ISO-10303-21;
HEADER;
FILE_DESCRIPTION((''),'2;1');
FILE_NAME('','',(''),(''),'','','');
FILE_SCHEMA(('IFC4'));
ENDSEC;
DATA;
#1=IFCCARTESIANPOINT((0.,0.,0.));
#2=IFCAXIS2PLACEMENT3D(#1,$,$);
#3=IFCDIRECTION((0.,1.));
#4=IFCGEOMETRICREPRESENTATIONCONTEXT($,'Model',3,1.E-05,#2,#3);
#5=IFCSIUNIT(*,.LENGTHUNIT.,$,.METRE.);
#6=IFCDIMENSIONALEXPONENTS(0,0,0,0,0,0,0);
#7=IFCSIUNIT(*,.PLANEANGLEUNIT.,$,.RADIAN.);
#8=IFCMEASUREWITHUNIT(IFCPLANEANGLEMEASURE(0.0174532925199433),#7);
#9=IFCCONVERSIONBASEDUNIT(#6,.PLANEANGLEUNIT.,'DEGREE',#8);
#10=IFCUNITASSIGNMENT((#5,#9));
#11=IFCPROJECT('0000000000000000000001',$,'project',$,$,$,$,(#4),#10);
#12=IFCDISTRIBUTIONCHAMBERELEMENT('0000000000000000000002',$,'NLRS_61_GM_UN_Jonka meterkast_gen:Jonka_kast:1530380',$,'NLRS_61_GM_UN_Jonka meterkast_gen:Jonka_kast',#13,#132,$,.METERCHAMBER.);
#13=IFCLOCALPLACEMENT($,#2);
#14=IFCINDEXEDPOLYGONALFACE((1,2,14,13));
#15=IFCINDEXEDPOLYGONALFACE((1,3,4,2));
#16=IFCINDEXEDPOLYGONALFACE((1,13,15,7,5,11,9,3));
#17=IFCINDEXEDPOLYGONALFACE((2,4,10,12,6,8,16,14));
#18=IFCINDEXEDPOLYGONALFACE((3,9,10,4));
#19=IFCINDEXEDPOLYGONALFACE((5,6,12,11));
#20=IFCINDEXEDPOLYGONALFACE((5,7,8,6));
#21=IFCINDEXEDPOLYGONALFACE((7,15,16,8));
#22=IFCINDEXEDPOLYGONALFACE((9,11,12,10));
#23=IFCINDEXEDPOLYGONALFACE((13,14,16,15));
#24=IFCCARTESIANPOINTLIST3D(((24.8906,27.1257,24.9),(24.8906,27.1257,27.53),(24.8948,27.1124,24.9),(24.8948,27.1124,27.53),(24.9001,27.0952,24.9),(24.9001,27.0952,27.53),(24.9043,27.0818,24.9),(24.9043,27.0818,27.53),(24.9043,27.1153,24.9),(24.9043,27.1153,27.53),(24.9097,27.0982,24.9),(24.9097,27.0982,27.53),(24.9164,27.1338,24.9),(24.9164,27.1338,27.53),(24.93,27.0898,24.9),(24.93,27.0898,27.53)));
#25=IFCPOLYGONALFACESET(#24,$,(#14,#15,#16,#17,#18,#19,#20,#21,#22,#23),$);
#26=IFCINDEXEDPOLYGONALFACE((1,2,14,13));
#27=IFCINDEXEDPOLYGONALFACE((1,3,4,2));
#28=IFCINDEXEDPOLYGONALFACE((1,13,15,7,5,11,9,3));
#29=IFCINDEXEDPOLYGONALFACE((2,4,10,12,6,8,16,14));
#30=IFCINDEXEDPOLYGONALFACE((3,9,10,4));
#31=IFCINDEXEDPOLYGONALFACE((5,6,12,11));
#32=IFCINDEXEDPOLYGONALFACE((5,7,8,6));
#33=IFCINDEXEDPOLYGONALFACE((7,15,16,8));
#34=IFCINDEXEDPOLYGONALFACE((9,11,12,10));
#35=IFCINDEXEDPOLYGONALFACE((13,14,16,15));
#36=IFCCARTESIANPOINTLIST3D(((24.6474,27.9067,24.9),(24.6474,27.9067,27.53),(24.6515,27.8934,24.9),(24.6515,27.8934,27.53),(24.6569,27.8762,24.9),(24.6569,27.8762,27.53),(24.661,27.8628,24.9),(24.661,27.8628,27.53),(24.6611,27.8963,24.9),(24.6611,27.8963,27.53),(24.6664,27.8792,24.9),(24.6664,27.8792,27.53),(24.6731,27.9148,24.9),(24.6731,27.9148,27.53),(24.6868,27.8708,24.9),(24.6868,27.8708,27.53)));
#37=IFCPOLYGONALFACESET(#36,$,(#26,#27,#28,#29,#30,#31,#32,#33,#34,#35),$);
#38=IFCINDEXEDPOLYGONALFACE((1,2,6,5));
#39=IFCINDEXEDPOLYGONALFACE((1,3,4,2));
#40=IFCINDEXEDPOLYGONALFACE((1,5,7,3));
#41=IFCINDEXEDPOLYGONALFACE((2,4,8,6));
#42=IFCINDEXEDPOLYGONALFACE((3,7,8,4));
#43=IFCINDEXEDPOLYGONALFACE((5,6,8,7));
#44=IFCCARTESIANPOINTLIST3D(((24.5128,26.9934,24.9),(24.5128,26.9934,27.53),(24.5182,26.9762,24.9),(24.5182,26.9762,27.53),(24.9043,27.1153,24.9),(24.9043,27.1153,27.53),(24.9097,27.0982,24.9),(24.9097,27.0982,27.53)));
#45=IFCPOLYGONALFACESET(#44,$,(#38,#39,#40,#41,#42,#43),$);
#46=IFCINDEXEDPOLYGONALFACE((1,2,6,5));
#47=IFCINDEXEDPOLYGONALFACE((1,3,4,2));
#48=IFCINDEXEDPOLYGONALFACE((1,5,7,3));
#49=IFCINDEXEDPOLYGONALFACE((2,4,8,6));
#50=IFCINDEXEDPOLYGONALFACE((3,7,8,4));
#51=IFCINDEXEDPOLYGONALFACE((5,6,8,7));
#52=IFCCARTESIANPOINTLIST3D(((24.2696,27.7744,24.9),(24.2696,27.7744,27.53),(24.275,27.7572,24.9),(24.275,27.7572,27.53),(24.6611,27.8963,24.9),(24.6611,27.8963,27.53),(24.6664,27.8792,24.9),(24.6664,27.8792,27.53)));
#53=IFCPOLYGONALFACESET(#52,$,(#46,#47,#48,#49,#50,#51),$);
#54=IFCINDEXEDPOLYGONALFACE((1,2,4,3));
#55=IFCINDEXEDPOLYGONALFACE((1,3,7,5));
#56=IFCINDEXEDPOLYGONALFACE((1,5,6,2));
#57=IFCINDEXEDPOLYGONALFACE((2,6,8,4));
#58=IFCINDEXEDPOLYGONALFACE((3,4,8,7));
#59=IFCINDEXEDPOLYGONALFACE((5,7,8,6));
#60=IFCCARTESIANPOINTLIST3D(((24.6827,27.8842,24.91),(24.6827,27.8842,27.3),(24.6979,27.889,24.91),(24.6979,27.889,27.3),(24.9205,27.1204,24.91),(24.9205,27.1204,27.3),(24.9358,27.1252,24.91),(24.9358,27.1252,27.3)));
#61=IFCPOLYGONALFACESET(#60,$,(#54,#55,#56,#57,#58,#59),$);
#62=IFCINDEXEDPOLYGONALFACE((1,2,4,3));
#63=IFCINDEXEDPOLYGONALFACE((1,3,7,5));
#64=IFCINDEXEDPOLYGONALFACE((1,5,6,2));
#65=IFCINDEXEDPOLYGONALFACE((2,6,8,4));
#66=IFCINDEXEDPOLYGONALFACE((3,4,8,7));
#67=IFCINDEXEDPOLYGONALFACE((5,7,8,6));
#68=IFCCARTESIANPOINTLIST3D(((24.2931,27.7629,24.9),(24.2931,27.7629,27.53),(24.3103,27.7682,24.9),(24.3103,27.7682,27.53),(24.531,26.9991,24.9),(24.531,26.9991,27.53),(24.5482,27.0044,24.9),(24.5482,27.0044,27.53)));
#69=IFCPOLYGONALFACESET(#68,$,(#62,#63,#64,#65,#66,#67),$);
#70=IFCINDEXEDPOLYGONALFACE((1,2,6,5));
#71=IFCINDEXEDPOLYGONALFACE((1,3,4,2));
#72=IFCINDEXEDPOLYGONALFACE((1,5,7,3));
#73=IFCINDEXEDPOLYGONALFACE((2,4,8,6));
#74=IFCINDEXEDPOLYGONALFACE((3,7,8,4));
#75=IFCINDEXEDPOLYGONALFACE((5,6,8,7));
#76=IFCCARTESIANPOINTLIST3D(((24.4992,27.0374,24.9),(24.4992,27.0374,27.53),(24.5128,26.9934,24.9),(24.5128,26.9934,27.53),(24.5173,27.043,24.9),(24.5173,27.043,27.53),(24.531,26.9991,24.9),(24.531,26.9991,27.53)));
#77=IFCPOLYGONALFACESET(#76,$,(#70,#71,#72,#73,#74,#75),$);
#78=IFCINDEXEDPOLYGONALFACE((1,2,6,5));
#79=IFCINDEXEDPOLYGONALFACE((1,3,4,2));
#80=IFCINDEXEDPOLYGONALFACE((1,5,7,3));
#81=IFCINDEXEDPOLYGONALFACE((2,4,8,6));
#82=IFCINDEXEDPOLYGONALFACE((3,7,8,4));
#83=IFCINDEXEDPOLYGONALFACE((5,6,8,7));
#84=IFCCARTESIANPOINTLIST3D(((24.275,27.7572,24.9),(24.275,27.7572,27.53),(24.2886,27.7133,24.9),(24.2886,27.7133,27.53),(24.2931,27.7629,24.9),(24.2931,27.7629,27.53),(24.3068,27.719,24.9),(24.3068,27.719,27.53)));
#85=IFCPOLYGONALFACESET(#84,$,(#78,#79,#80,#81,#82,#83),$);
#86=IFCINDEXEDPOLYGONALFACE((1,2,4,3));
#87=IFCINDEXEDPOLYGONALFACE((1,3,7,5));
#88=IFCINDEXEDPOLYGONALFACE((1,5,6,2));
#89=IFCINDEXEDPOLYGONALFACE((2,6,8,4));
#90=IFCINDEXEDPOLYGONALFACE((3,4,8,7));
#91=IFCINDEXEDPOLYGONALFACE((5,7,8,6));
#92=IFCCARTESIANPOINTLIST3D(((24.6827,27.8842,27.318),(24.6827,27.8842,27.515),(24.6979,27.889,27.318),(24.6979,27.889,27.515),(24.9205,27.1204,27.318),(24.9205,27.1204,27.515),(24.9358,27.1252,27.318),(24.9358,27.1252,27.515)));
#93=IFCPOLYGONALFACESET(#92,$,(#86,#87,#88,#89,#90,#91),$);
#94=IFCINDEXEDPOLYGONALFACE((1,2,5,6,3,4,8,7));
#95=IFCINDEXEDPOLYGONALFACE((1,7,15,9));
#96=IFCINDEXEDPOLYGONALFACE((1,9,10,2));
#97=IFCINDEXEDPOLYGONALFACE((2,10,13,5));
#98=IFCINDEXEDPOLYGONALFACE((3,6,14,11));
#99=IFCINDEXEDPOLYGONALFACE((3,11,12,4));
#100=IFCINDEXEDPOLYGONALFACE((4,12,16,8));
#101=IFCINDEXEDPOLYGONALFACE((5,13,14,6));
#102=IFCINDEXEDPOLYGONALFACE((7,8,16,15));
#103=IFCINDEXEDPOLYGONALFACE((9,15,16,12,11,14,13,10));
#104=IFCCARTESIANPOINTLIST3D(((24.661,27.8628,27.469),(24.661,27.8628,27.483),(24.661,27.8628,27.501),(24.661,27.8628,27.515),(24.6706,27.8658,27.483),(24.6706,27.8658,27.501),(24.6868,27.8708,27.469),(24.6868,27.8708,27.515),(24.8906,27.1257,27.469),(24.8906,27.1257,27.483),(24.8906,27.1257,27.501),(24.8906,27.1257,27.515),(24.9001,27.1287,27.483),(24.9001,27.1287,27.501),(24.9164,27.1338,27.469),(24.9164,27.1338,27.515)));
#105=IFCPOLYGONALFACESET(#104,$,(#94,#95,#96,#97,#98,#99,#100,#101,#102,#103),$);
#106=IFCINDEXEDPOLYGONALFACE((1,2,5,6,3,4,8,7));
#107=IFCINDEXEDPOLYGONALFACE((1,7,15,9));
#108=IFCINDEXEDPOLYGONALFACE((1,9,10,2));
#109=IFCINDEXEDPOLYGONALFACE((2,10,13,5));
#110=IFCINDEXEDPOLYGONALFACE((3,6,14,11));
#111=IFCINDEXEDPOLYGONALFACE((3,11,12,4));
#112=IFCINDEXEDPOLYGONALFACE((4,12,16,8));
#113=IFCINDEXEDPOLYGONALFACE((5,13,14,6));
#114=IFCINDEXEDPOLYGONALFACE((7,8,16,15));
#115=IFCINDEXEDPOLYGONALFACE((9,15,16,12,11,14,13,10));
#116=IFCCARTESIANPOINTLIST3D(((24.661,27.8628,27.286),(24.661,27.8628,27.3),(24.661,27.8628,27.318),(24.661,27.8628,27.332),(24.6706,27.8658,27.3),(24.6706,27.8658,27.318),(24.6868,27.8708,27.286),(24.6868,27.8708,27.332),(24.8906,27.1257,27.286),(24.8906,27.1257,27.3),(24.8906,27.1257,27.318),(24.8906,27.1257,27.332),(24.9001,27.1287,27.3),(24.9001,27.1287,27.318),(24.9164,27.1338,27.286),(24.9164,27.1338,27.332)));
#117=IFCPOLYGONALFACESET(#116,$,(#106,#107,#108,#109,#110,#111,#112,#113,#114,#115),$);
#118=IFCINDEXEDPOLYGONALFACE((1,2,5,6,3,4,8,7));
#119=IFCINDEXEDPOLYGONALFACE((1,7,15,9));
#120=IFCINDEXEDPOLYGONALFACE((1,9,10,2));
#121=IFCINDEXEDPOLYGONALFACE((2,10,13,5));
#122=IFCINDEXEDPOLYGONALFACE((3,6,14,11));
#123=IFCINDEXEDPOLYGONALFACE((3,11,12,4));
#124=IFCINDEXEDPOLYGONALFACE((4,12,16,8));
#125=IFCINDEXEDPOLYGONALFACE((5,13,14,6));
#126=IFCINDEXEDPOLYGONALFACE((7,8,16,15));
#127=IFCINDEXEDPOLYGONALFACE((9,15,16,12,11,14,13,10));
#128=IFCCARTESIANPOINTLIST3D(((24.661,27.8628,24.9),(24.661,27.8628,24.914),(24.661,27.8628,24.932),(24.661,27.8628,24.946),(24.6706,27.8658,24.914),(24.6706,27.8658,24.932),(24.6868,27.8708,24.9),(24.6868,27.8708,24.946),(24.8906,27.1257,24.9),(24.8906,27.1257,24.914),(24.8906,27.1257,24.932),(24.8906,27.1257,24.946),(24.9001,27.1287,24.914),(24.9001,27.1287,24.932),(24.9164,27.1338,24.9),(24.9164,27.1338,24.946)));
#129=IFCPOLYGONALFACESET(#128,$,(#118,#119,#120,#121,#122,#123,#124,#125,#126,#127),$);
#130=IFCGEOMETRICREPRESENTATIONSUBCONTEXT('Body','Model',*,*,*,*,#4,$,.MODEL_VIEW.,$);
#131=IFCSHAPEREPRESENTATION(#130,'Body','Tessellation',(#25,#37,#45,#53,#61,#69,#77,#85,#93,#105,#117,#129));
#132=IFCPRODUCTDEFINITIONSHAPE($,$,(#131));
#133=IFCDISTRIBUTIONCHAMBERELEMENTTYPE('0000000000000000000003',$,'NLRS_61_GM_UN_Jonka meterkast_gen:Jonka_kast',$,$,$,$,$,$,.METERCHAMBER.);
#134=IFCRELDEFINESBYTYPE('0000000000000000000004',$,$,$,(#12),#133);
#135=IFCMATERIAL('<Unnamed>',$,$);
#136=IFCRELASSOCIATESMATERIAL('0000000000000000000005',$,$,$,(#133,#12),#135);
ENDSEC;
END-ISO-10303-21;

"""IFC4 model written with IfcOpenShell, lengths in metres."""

from ifc_helpers import new_model, entity, si_unit, converted_unit, direction, frame, origin, place, context, subcontext, project, indexed_curve, outline, extrude, source, transform, mapped, material, type_object, type_shapes, element, save


model = new_model("IFC4")

# Units and contexts
model_context = context("Model", 3, precision=1e-05, world=origin(), true_north=direction((0.0, 1.0)))
body_context = subcontext(model_context, "Body", "Model", "MODEL_VIEW")
ifc_project = project(units=[si_unit("LENGTHUNIT", "METRE"), converted_unit("PLANEANGLEUNIT", "DEGREE", entity("IfcPlaneAngleMeasure", 0.0174532925199433), si_unit("PLANEANGLEUNIT", "RADIAN"), dimensions=[0, 0, 0, 0, 0, 0, 0])], contexts=[model_context])

# Distribution chamber element
ifc_material = material(Name="<Unnamed>")
distribution_chamber_element_type = type_object("IfcDistributionChamberElementType", Name="NLRS_61_GM_UN_Jonka meterkast_gen:Jonka_kast", PredefinedType="METERCHAMBER", material=ifc_material)
shared_shape_1 = source(origin(), body_context, "Body", "SweptSolid", [
    extrude(outline(indexed_curve([(-0.0093, -0.023), (0.0178, -0.023), (0.0178, 0.023), (-0.0093, 0.023), (-0.0093, 0.009), (0.0007, 0.009), (0.0007, -0.009), (-0.0093, -0.009), (-0.0093, -0.023)], self_intersect=False)), frame((-0.409, -0.4092, 0.0), z_axis=(0.0, 0.0, 1.0), x_axis=(0.0, -1.0, 0.0)), (0.0, 0.0, 1.0), 2.63),
    extrude(outline(indexed_curve([(-0.0093, -0.023), (0.0178, -0.023), (0.0178, 0.023), (-0.0093, 0.023), (-0.0093, 0.009), (0.0007, 0.009), (0.0007, -0.009), (-0.0093, -0.009), (-0.0093, -0.023)], self_intersect=False)), frame((0.409, -0.4092, 0.0), z_axis=(0.0, 0.0, 1.0), x_axis=(0.0, -1.0, 0.0)), (0.0, 0.0, 1.0), 2.63),
    extrude(outline(indexed_curve([(-0.205, -0.009), (0.205, -0.009), (0.205, 0.009), (-0.205, 0.009), (-0.205, -0.009)], self_intersect=False)), frame((-0.409, -0.205, 0.0), z_axis=(0.0, 0.0, 1.0), x_axis=(0.0, -1.0, 0.0)), (0.0, 0.0, 1.0), 2.63),
    extrude(outline(indexed_curve([(-0.205, -0.009), (0.205, -0.009), (0.205, 0.009), (-0.205, 0.009), (-0.205, -0.009)], self_intersect=False)), frame((0.409, -0.205, 0.0), z_axis=(0.0, 0.0, 1.0), x_axis=(0.0, -1.0, 0.0)), (0.0, 0.0, 1.0), 2.63),
    extrude(outline(indexed_curve([(-0.4, -0.008), (0.4, -0.008), (0.4, 0.008), (-0.4, 0.008), (-0.4, -0.008)], self_intersect=False)), frame((0.0, -0.435, 0.01), z_axis=(0.0, 0.0, 1.0), x_axis=(-1.0, 0.0, 0.0)), (0.0, 0.0, 1.0), 2.39),
    extrude(outline(indexed_curve([(-0.4, -0.009), (0.4, -0.009), (0.4, 0.009), (-0.4, 0.009), (-0.4, -0.009)], self_intersect=False)), frame((0.0, -0.028, 0.0), z_axis=(0.0, 0.0, 1.0), x_axis=(-1.0, 0.0, 0.0)), (0.0, 0.0, 1.0), 2.63),
    extrude(outline(indexed_curve([(-0.023, -0.0095), (0.023, -0.0095), (0.023, 0.0095), (-0.023, 0.0095), (-0.023, -0.0095)], self_intersect=False)), frame((-0.377, -0.0095, 0.0), z_axis=(0.0, 0.0, 1.0), x_axis=(-1.0, 0.0, 0.0)), (0.0, 0.0, 1.0), 2.63),
    extrude(outline(indexed_curve([(-0.023, -0.0095), (0.023, -0.0095), (0.023, 0.0095), (-0.023, 0.0095), (-0.023, -0.0095)], self_intersect=False)), frame((0.377, -0.0095, 0.0), z_axis=(0.0, 0.0, 1.0), x_axis=(-1.0, 0.0, 0.0)), (0.0, 0.0, 1.0), 2.63),
    extrude(outline(indexed_curve([(-0.4, -0.008), (0.4, -0.008), (0.4, 0.008), (-0.4, 0.008), (-0.4, -0.008)], self_intersect=False)), frame((0.0, -0.435, 2.418), z_axis=(0.0, 0.0, 1.0), x_axis=(-1.0, 0.0, 0.0)), (0.0, 0.0, 1.0), 0.197),
    extrude(outline(indexed_curve([(-0.023, -0.0178), (0.023, -0.0178), (0.023, 0.0093), (0.009, 0.0093), (0.009, -0.0007), (-0.009, -0.0007), (-0.009, 0.0093), (-0.023, 0.0093), (-0.023, -0.0178)], self_intersect=False)), frame((-0.386, -0.4092, 2.592), z_axis=(1.0, 0.0, 0.0), x_axis=(0.0, 0.0, -1.0)), (0.0, 0.0, 1.0), 0.772),
    extrude(outline(indexed_curve([(-0.023, -0.0178), (0.023, -0.0178), (0.023, 0.0093), (0.009, 0.0093), (0.009, -0.0007), (-0.009, -0.0007), (-0.009, 0.0093), (-0.023, 0.0093), (-0.023, -0.0178)], self_intersect=False)), frame((-0.386, -0.4092, 2.409), z_axis=(1.0, 0.0, 0.0), x_axis=(0.0, 0.0, -1.0)), (0.0, 0.0, 1.0), 0.772),
    extrude(outline(indexed_curve([(-0.023, -0.0178), (0.023, -0.0178), (0.023, 0.0093), (0.009, 0.0093), (0.009, -0.0007), (-0.009, -0.0007), (-0.009, 0.0093), (-0.023, 0.0093), (-0.023, -0.0178)], self_intersect=False)), frame((-0.386, -0.4092, 0.023), z_axis=(1.0, 0.0, 0.0), x_axis=(0.0, 0.0, -1.0)), (0.0, 0.0, 1.0), 0.772),
])
type_shapes(distribution_chamber_element_type, [shared_shape_1])
placement_1 = place(None, frame((13.1348, 11.9886, 0.0), z_axis=(0.0, 0.0, 1.0), x_axis=(0.954771, 0.297342, 0.0)))
placement_2 = place(placement_1, origin())
placement_3 = place(placement_2, frame((0.0, 0.0, 24.9)))
placement_4 = place(placement_3, origin())
distribution_chamber_element_1_placement = place(placement_4, frame((15.325, 11.343, 0.0), z_axis=(0.0, 0.0, 1.0), x_axis=(0.0, 1.0, 0.0)))
element("IfcDistributionChamberElement", 1, at=distribution_chamber_element_1_placement, type_object=distribution_chamber_element_type, material=ifc_material, Name="NLRS_61_GM_UN_Jonka meterkast_gen:Jonka_kast:1530380", ObjectType="NLRS_61_GM_UN_Jonka meterkast_gen:Jonka_kast", PredefinedType="METERCHAMBER", context=body_context, shape_type="MappedRepresentation", body=[
    mapped(shared_shape_1, transform((0.0, 0.0, 0.0), scale=1.0)),
])

save(model, "model.ifc")
